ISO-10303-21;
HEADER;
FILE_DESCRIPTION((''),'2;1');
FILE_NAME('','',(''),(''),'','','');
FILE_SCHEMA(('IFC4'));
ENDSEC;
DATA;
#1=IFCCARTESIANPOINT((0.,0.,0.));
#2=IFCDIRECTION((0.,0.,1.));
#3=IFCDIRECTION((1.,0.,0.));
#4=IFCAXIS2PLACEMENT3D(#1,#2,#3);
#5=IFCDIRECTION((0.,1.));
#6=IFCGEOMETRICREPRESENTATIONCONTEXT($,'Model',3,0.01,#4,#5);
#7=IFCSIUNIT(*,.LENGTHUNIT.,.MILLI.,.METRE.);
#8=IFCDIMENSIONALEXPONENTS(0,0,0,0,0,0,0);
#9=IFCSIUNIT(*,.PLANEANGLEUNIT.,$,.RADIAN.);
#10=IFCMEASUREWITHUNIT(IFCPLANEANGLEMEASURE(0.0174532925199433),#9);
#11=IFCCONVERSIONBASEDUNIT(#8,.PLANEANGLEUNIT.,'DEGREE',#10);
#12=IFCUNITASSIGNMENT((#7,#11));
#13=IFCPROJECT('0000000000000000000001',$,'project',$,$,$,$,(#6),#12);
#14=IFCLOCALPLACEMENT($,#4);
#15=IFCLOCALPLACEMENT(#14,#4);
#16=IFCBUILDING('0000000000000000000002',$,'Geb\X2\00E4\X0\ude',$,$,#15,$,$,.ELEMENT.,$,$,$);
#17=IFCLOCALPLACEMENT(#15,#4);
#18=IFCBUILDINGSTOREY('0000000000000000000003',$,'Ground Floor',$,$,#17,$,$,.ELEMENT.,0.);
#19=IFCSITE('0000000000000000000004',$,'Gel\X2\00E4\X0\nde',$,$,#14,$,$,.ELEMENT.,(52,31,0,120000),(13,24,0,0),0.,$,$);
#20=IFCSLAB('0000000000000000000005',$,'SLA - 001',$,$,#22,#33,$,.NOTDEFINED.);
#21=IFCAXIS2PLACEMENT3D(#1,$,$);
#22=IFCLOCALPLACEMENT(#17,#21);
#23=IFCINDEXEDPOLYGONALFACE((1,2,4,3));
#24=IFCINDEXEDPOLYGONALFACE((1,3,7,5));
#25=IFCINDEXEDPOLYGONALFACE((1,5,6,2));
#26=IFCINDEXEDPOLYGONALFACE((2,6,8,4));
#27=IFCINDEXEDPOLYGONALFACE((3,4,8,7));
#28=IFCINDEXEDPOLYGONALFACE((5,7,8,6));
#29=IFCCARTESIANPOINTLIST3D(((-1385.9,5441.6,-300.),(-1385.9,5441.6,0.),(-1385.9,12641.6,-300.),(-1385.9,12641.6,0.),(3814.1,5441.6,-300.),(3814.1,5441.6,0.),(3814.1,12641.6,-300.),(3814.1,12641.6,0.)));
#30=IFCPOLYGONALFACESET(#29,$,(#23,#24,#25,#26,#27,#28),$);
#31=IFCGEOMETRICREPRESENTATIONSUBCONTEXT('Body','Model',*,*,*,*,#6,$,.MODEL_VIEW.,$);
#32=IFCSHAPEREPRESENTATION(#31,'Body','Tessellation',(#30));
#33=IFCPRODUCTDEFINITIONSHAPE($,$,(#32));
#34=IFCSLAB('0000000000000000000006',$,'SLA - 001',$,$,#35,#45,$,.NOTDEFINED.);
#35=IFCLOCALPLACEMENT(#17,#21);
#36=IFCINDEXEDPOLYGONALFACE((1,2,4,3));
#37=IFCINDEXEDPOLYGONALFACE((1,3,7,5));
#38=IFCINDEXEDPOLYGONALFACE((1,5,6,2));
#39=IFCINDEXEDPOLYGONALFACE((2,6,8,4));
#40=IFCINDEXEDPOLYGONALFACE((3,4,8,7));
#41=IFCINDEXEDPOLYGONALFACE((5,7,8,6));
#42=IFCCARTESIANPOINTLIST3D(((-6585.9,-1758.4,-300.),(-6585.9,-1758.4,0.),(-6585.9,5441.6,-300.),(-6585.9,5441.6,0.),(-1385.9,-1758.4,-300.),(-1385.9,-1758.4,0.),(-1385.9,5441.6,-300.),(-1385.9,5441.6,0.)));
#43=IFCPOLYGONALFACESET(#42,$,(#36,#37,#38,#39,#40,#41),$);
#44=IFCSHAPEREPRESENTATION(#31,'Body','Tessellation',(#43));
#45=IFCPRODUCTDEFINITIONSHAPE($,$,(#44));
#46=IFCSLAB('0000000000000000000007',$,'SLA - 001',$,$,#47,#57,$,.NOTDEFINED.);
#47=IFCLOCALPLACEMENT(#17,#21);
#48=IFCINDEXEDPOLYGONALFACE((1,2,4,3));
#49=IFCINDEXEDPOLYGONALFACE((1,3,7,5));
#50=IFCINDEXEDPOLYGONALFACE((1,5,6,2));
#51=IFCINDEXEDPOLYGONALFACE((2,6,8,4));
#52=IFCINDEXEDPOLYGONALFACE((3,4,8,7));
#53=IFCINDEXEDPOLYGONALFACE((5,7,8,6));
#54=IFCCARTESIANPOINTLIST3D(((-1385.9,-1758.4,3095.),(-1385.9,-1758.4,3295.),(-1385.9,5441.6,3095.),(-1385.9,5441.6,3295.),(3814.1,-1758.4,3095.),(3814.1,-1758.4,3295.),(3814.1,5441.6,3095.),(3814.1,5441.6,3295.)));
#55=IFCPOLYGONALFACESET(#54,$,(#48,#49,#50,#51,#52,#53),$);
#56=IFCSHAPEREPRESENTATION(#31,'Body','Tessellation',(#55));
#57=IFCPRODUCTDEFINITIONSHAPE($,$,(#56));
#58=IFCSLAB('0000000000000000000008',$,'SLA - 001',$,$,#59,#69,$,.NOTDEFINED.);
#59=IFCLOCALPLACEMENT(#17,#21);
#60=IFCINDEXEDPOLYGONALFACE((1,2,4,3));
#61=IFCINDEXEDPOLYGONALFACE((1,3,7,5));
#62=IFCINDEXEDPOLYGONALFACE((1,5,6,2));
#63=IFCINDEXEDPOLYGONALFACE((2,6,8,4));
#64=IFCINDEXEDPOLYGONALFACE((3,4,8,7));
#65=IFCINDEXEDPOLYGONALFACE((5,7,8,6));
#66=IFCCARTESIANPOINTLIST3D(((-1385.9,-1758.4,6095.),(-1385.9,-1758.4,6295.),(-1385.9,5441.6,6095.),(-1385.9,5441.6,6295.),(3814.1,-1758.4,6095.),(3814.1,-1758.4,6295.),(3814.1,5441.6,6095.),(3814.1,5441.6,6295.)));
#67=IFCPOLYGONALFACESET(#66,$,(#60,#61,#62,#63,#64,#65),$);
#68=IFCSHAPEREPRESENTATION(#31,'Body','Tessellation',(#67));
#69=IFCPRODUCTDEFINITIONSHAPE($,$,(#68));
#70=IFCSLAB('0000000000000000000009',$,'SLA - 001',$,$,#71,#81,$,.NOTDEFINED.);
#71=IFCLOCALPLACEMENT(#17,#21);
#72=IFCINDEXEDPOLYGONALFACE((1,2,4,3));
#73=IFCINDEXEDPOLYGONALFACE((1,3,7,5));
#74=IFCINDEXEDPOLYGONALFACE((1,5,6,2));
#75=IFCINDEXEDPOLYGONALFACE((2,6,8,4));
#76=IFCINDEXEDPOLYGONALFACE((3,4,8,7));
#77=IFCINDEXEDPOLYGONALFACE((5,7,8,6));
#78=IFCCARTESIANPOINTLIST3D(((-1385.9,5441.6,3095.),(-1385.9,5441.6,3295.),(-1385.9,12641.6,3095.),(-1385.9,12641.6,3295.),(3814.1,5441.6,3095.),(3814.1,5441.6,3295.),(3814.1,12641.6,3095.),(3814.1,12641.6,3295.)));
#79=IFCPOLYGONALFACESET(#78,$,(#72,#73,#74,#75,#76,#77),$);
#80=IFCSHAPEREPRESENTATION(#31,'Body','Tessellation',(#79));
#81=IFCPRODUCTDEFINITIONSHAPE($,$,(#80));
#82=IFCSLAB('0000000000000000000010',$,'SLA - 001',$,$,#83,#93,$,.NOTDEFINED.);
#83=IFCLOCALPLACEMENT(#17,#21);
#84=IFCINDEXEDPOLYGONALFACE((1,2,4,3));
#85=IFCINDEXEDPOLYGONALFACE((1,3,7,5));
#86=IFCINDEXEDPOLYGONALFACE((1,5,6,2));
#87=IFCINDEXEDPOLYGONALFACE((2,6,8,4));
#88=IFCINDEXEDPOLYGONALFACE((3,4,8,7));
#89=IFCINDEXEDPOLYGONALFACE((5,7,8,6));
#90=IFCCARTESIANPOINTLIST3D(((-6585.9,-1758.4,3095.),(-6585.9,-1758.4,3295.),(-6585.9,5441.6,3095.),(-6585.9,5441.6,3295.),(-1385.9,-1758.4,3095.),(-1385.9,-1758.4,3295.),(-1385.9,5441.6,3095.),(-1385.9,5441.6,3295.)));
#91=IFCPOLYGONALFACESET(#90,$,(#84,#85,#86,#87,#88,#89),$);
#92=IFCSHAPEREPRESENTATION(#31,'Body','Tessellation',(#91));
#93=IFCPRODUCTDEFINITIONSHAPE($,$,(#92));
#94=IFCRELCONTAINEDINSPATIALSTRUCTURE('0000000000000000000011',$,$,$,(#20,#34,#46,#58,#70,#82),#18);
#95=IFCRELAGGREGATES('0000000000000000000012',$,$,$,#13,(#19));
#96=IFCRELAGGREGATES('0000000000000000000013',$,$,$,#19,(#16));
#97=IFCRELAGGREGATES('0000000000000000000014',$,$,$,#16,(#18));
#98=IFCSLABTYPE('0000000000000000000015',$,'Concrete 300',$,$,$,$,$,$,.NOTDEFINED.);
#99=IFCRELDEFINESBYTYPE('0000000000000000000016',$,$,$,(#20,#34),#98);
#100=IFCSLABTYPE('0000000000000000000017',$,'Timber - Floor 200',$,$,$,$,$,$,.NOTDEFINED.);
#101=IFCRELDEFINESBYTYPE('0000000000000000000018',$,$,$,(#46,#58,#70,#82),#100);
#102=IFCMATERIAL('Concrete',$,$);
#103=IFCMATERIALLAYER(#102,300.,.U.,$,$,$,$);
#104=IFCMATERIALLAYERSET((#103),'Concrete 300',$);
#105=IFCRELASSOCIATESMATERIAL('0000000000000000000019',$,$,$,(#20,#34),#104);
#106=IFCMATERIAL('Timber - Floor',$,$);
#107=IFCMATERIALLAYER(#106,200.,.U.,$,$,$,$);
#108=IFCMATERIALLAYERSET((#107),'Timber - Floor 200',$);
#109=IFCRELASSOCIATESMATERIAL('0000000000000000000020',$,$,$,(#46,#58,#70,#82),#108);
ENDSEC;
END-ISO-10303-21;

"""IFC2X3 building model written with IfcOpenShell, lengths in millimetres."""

from ifc_helpers import new_model, entity, si_unit, converted_unit, direction, frame, origin_with_axes, place, context, subcontext, project, spatial, polyline, outline, extrude, material, layer, layer_set, layer_usage, type_object, element, save


model = new_model("IFC2X3")

# Units and contexts
model_context = context("Model", 3, precision=0.01, world=origin_with_axes(), true_north=direction((0.0, 1.0)))
body_context = subcontext(model_context, "Body", "Model", "MODEL_VIEW")
ifc_project = project(units=[si_unit("LENGTHUNIT", "METRE", prefix="MILLI"), converted_unit("PLANEANGLEUNIT", "DEGREE", entity("IfcPlaneAngleMeasure", 0.0174532925199433), si_unit("PLANEANGLEUNIT", "RADIAN"), dimensions=[0, 0, 0, 0, 0, 0, 0])], contexts=[model_context])

# Site, building, storey
site_placement = place(None, origin_with_axes())
site = spatial("IfcSite", under=ifc_project, at=site_placement, Name="Gelände", CompositionType="ELEMENT", RefLatitude=(52, 31, 0, 120000), RefLongitude=(13, 24, 0, 0), RefElevation=0.0)
building_placement = place(site_placement, origin_with_axes())
building = spatial("IfcBuilding", under=site, at=building_placement, Name="Gebäude", CompositionType="ELEMENT")
storey_placement = place(building_placement, origin_with_axes())
storey = spatial("IfcBuildingStorey", under=building, at=storey_placement, Name="Ground Floor", CompositionType="ELEMENT", Elevation=0.0)

# Slabs
ifc_material_1 = material(Name="Concrete")
ifc_layer_1 = layer(ifc_material_1, 300.0, ventilated="UNKNOWN")
ifc_layer_set_1 = layer_set([ifc_layer_1], Name="Concrete 300")
slab_type_1 = type_object("IfcSlabType", Name="Concrete 300", PredefinedType="NOTDEFINED")
ifc_layer_usage_1 = layer_usage(ifc_layer_set_1, "AXIS3", "NEGATIVE", 300.0)
slab_1_placement = place(storey_placement, frame((-1385.9, 5441.6, 0.0), z_axis=(0.0, 0.0, 1.0), x_axis=(1.0, 0.0, 0.0)))
element("IfcSlab", 1, at=slab_1_placement, inside=storey, type_object=slab_type_1, material=ifc_layer_usage_1, Name="SLA - 001", PredefinedType="NOTDEFINED", context=body_context, shape_type="SweptSolid", body=[
    extrude(outline(polyline([(0.0, 0.0), (5200.0, 0.0), (5200.0, 7200.0), (0.0, 7200.0), (0.0, 0.0)])), frame((0.0, 0.0, -300.0), z_axis=(0.0, 0.0, 1.0), x_axis=(1.0, 0.0, 0.0)), (0.0, 0.0, 1.0), 300.0),
])
ifc_layer_usage_2 = layer_usage(ifc_layer_set_1, "AXIS3", "NEGATIVE", 300.0)
slab_2_placement = place(storey_placement, frame((-6585.9, -1758.4, 0.0), z_axis=(0.0, 0.0, 1.0), x_axis=(1.0, 0.0, 0.0)))
element("IfcSlab", 2, at=slab_2_placement, inside=storey, type_object=slab_type_1, material=ifc_layer_usage_2, Name="SLA - 001", PredefinedType="NOTDEFINED", context=body_context, shape_type="SweptSolid", body=[
    extrude(outline(polyline([(0.0, 0.0), (5200.0, 0.0), (5200.0, 7200.0), (0.0, 7200.0), (0.0, 0.0)])), frame((0.0, 0.0, -300.0), z_axis=(0.0, 0.0, 1.0), x_axis=(1.0, 0.0, 0.0)), (0.0, 0.0, 1.0), 300.0),
])
ifc_material_2 = material(Name="Timber - Floor")
ifc_layer_2 = layer(ifc_material_2, 200.0, ventilated="UNKNOWN")
ifc_layer_set_2 = layer_set([ifc_layer_2], Name="Timber - Floor 200")
ifc_layer_usage_3 = layer_usage(ifc_layer_set_2, "AXIS3", "NEGATIVE", 200.0)
slab_type_2 = type_object("IfcSlabType", Name="Timber - Floor 200", PredefinedType="NOTDEFINED")
slab_3_placement = place(storey_placement, frame((-1385.9, -1758.4, 3295.0), z_axis=(0.0, 0.0, 1.0), x_axis=(1.0, 0.0, 0.0)))
element("IfcSlab", 3, at=slab_3_placement, inside=storey, type_object=slab_type_2, material=ifc_layer_usage_3, Name="SLA - 001", PredefinedType="NOTDEFINED", context=body_context, shape_type="SweptSolid", body=[
    extrude(outline(polyline([(0.0, 0.0), (5200.0, 0.0), (5200.0, 7200.0), (0.0, 7200.0), (0.0, 0.0)])), frame((0.0, 0.0, -200.0), z_axis=(0.0, 0.0, 1.0), x_axis=(1.0, 0.0, 0.0)), (0.0, 0.0, 1.0), 200.0),
])
ifc_layer_usage_4 = layer_usage(ifc_layer_set_2, "AXIS3", "NEGATIVE", 200.0)
slab_4_placement = place(storey_placement, frame((-1385.9, -1758.4, 6295.0), z_axis=(0.0, 0.0, 1.0), x_axis=(1.0, 0.0, 0.0)))
element("IfcSlab", 4, at=slab_4_placement, inside=storey, type_object=slab_type_2, material=ifc_layer_usage_4, Name="SLA - 001", PredefinedType="NOTDEFINED", context=body_context, shape_type="SweptSolid", body=[
    extrude(outline(polyline([(0.0, 0.0), (5200.0, 0.0), (5200.0, 7200.0), (0.0, 7200.0), (0.0, 0.0)])), frame((0.0, 0.0, -200.0), z_axis=(0.0, 0.0, 1.0), x_axis=(1.0, 0.0, 0.0)), (0.0, 0.0, 1.0), 200.0),
])
ifc_layer_usage_5 = layer_usage(ifc_layer_set_2, "AXIS3", "NEGATIVE", 200.0)
slab_5_placement = place(storey_placement, frame((-1385.9, 5441.6, 3295.0), z_axis=(0.0, 0.0, 1.0), x_axis=(1.0, 0.0, 0.0)))
element("IfcSlab", 5, at=slab_5_placement, inside=storey, type_object=slab_type_2, material=ifc_layer_usage_5, Name="SLA - 001", PredefinedType="NOTDEFINED", context=body_context, shape_type="SweptSolid", body=[
    extrude(outline(polyline([(0.0, 0.0), (5200.0, 0.0), (5200.0, 7200.0), (0.0, 7200.0), (0.0, 0.0)])), frame((0.0, 0.0, -200.0), z_axis=(0.0, 0.0, 1.0), x_axis=(1.0, 0.0, 0.0)), (0.0, 0.0, 1.0), 200.0),
])
ifc_layer_usage_6 = layer_usage(ifc_layer_set_2, "AXIS3", "NEGATIVE", 200.0)
slab_6_placement = place(storey_placement, frame((-6585.9, -1758.4, 3295.0), z_axis=(0.0, 0.0, 1.0), x_axis=(1.0, 0.0, 0.0)))
element("IfcSlab", 6, at=slab_6_placement, inside=storey, type_object=slab_type_2, material=ifc_layer_usage_6, Name="SLA - 001", PredefinedType="NOTDEFINED", context=body_context, shape_type="SweptSolid", body=[
    extrude(outline(polyline([(0.0, 0.0), (5200.0, 0.0), (5200.0, 7200.0), (0.0, 7200.0), (0.0, 0.0)])), frame((0.0, 0.0, -200.0), z_axis=(0.0, 0.0, 1.0), x_axis=(1.0, 0.0, 0.0)), (0.0, 0.0, 1.0), 200.0),
])

save(model, "model.ifc")
